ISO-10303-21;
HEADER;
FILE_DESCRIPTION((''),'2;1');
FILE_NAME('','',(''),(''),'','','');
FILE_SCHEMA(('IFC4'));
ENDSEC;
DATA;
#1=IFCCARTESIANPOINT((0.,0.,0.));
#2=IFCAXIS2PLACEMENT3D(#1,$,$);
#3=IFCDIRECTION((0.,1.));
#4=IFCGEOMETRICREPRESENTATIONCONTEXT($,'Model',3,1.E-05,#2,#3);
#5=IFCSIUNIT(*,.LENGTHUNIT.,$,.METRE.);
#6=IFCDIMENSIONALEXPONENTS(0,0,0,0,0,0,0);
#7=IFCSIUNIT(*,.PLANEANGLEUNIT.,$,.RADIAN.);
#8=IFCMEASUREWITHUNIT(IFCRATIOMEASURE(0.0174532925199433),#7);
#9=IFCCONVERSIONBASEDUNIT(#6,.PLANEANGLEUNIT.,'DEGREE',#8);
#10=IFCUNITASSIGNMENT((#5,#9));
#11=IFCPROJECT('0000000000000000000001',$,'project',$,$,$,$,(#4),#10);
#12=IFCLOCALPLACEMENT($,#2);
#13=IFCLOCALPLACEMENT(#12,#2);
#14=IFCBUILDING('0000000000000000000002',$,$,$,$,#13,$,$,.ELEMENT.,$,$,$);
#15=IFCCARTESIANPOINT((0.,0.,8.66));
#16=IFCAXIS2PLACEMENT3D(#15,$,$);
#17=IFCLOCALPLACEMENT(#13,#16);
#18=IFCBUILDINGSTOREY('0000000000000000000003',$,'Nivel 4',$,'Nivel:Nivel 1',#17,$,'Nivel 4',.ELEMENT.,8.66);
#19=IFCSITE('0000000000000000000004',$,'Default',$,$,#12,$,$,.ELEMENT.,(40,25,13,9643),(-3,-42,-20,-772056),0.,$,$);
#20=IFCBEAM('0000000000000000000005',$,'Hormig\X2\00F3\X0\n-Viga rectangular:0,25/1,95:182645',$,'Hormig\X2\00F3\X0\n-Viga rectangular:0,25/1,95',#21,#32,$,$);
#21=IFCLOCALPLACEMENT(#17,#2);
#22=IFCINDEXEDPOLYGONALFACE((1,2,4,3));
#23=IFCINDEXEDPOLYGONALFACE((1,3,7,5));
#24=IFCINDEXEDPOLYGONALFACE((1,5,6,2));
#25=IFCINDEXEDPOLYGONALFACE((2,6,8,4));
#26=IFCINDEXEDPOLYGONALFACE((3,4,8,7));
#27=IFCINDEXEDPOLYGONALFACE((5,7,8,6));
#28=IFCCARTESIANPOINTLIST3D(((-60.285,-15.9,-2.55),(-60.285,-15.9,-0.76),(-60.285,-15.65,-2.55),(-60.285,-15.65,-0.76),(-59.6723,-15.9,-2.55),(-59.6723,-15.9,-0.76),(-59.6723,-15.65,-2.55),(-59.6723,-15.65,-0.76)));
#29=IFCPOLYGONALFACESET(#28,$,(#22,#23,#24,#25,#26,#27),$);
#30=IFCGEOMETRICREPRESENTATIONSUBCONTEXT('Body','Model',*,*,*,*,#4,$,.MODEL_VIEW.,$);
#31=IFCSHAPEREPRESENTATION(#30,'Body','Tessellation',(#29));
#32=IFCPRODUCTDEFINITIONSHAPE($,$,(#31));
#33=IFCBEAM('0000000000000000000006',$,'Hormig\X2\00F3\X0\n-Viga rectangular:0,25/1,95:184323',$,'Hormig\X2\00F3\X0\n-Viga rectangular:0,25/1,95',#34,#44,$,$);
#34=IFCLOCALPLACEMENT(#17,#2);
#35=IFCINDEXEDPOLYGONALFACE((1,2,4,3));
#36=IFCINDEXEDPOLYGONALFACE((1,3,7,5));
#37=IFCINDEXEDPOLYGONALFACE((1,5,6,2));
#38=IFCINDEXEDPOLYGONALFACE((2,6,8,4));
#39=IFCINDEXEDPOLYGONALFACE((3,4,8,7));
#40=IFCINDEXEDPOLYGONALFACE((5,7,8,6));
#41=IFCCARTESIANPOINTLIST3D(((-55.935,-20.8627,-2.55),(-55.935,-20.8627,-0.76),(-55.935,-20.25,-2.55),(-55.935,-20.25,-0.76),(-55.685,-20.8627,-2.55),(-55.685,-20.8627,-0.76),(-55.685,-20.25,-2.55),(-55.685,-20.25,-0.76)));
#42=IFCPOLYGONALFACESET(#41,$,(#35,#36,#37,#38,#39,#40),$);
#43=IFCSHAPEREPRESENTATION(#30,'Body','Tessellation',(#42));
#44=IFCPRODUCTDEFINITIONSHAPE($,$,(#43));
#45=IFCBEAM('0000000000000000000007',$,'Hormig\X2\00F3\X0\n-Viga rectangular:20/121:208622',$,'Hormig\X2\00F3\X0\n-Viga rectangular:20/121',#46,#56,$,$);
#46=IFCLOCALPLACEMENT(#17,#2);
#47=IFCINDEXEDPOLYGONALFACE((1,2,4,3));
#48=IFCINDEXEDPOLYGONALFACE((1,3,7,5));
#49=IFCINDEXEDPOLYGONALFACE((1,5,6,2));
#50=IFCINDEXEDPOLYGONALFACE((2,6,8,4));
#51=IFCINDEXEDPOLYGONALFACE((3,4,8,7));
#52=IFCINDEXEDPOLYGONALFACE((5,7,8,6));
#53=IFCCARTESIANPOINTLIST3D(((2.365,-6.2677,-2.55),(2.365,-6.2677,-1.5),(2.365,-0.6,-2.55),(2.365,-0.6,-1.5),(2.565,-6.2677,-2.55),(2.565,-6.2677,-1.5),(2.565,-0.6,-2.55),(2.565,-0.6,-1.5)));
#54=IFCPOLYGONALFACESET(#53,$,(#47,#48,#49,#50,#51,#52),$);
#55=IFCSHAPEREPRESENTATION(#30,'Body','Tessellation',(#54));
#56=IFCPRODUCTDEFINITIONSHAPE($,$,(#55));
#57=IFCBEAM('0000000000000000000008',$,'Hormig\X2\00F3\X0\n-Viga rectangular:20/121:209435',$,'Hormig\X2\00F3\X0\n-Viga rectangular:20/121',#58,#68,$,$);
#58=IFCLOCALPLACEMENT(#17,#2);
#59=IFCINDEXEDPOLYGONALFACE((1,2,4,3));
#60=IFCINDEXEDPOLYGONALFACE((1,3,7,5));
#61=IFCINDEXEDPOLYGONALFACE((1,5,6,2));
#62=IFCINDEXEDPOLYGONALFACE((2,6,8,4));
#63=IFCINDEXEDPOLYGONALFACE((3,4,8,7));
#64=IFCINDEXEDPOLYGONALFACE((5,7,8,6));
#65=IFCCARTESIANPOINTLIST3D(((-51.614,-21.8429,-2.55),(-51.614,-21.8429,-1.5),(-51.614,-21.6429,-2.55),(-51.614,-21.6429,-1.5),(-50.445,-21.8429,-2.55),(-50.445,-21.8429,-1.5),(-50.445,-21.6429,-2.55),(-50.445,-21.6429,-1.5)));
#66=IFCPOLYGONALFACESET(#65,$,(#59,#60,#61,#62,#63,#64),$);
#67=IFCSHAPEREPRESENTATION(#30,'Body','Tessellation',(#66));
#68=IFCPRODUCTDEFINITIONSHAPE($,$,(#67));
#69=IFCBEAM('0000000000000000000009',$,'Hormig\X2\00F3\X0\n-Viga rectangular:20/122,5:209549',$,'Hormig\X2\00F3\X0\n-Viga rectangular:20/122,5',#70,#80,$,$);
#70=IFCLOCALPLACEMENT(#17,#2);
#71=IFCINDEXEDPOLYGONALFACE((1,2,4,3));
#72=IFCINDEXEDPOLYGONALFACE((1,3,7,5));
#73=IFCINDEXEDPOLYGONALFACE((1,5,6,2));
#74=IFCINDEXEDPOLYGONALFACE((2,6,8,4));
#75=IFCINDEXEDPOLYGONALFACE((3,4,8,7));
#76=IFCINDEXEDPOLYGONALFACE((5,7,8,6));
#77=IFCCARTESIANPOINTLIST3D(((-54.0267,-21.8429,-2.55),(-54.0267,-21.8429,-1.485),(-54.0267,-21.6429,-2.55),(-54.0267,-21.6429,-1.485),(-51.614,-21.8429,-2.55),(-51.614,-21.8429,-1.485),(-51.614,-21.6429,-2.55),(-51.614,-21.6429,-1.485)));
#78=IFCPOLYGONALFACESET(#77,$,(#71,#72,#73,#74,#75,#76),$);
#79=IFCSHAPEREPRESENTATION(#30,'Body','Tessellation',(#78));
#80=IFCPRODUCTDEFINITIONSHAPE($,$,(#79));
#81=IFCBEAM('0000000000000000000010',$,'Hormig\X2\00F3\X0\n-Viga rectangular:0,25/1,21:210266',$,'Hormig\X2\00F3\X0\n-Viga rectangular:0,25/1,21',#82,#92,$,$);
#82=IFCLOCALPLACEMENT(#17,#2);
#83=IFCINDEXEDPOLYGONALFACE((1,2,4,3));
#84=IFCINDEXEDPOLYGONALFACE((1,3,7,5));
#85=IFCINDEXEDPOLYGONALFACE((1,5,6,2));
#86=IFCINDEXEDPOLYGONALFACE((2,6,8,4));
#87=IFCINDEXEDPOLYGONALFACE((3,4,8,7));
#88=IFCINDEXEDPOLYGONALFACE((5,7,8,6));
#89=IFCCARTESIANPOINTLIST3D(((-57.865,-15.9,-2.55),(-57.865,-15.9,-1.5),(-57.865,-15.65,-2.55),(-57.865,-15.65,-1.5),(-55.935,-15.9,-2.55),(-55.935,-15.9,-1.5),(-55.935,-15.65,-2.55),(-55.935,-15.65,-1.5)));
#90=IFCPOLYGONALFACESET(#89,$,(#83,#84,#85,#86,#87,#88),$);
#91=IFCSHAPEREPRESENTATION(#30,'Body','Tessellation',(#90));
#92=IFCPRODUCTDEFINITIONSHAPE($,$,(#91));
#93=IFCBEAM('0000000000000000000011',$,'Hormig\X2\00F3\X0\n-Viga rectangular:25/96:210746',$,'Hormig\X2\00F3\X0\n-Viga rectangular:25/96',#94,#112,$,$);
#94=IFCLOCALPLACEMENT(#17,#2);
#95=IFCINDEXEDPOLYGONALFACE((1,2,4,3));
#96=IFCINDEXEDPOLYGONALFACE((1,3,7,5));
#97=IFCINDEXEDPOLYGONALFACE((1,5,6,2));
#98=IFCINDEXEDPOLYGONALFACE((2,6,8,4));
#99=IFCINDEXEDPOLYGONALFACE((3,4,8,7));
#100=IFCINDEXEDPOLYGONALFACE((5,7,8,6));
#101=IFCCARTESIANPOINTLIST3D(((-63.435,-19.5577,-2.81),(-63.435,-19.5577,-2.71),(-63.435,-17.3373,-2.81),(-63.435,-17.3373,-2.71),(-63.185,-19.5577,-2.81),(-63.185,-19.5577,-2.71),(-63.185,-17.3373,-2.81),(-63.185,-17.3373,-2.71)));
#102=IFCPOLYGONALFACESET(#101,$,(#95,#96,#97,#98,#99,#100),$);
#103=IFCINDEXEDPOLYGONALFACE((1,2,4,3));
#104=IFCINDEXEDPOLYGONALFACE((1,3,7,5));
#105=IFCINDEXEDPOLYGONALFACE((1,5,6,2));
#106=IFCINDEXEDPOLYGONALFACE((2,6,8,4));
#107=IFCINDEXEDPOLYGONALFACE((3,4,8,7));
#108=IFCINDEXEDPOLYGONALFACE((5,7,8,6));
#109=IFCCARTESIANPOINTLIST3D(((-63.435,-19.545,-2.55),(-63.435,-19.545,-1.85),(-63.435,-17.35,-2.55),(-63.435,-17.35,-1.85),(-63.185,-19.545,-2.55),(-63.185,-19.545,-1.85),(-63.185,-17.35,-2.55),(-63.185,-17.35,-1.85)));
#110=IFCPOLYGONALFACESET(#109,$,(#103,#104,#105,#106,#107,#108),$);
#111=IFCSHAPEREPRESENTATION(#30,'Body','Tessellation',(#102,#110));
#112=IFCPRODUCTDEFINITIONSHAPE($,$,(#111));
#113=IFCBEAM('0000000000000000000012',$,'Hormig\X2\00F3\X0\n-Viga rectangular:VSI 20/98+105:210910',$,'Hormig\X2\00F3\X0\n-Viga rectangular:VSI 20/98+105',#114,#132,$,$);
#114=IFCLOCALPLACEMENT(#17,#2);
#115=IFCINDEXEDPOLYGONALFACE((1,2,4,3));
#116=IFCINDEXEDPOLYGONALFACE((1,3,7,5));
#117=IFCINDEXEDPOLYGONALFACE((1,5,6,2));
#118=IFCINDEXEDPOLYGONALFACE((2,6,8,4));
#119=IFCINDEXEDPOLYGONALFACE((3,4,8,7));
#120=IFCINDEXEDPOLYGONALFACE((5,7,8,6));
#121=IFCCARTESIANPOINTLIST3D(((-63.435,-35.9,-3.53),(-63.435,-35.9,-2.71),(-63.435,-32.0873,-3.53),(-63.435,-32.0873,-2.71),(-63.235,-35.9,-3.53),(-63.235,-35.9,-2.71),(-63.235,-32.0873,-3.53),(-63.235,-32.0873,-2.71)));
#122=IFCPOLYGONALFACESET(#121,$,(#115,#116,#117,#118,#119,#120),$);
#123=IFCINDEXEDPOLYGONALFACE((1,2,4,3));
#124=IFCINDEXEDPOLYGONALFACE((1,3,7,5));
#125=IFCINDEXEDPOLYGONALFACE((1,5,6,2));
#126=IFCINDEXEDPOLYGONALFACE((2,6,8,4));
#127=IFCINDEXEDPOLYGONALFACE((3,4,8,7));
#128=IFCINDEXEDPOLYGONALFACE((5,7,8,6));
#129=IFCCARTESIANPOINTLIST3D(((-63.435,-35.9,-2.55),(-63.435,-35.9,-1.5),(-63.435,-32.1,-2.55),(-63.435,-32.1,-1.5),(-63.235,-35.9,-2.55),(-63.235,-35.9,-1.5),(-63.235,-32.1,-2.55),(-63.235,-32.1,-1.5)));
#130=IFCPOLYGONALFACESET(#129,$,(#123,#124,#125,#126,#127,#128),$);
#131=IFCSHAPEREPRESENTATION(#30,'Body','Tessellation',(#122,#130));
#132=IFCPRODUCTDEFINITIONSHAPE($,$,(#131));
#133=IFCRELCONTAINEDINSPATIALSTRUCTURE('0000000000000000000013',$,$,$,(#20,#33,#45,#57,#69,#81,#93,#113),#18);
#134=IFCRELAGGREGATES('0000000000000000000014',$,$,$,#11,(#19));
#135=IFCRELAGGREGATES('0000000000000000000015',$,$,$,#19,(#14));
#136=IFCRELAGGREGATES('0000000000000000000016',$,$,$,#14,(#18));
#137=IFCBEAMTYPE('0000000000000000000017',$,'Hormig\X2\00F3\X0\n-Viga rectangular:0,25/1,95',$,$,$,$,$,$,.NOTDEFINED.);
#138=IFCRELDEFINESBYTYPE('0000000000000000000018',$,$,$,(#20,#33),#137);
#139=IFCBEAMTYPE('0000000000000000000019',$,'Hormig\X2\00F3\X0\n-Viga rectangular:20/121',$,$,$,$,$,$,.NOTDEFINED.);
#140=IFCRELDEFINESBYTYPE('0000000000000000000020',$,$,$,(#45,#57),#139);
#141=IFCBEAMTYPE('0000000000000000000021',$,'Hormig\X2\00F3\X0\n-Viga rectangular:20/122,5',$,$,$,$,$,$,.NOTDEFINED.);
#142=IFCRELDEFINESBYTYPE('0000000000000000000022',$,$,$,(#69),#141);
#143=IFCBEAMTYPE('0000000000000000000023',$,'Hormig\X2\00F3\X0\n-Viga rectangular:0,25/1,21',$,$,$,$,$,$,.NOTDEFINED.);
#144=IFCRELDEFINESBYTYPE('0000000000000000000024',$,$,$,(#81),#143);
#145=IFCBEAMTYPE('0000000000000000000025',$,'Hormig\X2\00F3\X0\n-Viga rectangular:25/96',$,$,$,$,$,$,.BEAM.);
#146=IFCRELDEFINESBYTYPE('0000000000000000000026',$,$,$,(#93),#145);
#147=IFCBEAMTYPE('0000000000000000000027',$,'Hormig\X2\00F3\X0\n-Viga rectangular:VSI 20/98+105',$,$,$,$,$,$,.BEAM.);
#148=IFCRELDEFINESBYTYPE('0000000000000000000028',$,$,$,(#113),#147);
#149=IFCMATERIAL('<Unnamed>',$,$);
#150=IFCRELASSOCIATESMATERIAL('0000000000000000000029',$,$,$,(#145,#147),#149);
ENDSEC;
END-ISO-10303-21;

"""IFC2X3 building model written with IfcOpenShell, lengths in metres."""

from ifc_helpers import new_model, entity, si_unit, converted_unit, direction, frame, frame_2d, origin, place, context, subcontext, project, spatial, rectangle, extrude, source, transform, mapped, material, type_object, type_shapes, element, save


model = new_model("IFC2X3")

# Units and contexts
model_context = context("Model", 3, precision=1e-05, world=origin(), true_north=direction((0.0, 1.0)))
body_context = subcontext(model_context, "Body", "Model", "MODEL_VIEW")
ifc_project = project(units=[si_unit("LENGTHUNIT", "METRE"), converted_unit("PLANEANGLEUNIT", "DEGREE", entity("IfcRatioMeasure", 0.0174532925199433), si_unit("PLANEANGLEUNIT", "RADIAN"), dimensions=[0, 0, 0, 0, 0, 0, 0])], contexts=[model_context])

# Site, building, storey
site_placement = place(None, origin())
site = spatial("IfcSite", under=ifc_project, at=site_placement, Name="Default", CompositionType="ELEMENT", RefLatitude=(40, 25, 13, 9643), RefLongitude=(-3, -42, -20, -772056), RefElevation=0.0)
building_placement = place(site_placement, origin())
building = spatial("IfcBuilding", under=site, at=building_placement, CompositionType="ELEMENT")
storey_placement = place(building_placement, frame((0.0, 0.0, 8.66)))
storey = spatial("IfcBuildingStorey", under=building, at=storey_placement, Name="Nivel 4", ObjectType="Nivel:Nivel 1", LongName="Nivel 4", CompositionType="ELEMENT", Elevation=8.66)

# Beams
beam_type_1 = type_object("IfcBeamType", Name="Hormigón-Viga rectangular:0,25/1,95", PredefinedType="NOTDEFINED")
beam_1_placement = place(storey_placement, frame((-60.285, -15.775, -0.76)))
element("IfcBeam", 1, at=beam_1_placement, inside=storey, type_object=beam_type_1, Name="Hormigón-Viga rectangular:0,25/1,95:182645", ObjectType="Hormigón-Viga rectangular:0,25/1,95", context=body_context, shape_type="SweptSolid", body=[
    extrude(rectangle(XDim=1.79, YDim=0.25, at=frame_2d((0.0, 0.0), x_axis=(1.0, 0.0))), frame((0.0, 0.0, -0.895), z_axis=(1.0, 0.0, 0.0), x_axis=(0.0, 0.0, -1.0)), (0.0, 0.0, 1.0), 0.6127),
])
beam_2_placement = place(storey_placement, frame((-55.81, -20.25, -0.76), z_axis=(0.0, 0.0, 1.0), x_axis=(0.0, -1.0, 0.0)))
element("IfcBeam", 2, at=beam_2_placement, inside=storey, type_object=beam_type_1, Name="Hormigón-Viga rectangular:0,25/1,95:184323", ObjectType="Hormigón-Viga rectangular:0,25/1,95", context=body_context, shape_type="SweptSolid", body=[
    extrude(rectangle(XDim=1.79, YDim=0.25, at=frame_2d((0.0, 0.0), x_axis=(1.0, 0.0))), frame((0.0, 0.0, -0.895), z_axis=(1.0, 0.0, 0.0), x_axis=(0.0, 0.0, -1.0)), (0.0, 0.0, 1.0), 0.6127),
])
beam_type_2 = type_object("IfcBeamType", Name="Hormigón-Viga rectangular:20/121", PredefinedType="NOTDEFINED")
beam_3_placement = place(storey_placement, frame((2.465, -0.475, -1.5), z_axis=(0.0, 0.0, 1.0), x_axis=(0.0, -1.0, 0.0)))
element("IfcBeam", 3, at=beam_3_placement, inside=storey, type_object=beam_type_2, Name="Hormigón-Viga rectangular:20/121:208622", ObjectType="Hormigón-Viga rectangular:20/121", context=body_context, shape_type="SweptSolid", body=[
    extrude(rectangle(XDim=1.05, YDim=0.2, at=frame_2d((0.0, 0.0), x_axis=(1.0, 0.0))), frame((0.125, 0.0, -0.525), z_axis=(1.0, 0.0, 0.0), x_axis=(0.0, 0.0, -1.0)), (0.0, 0.0, 1.0), 5.6677),
])
beam_4_placement = place(storey_placement, frame((-51.6267, -21.7429, -1.5)))
element("IfcBeam", 4, at=beam_4_placement, inside=storey, type_object=beam_type_2, Name="Hormigón-Viga rectangular:20/121:209435", ObjectType="Hormigón-Viga rectangular:20/121", context=body_context, shape_type="SweptSolid", body=[
    extrude(rectangle(XDim=1.05, YDim=0.2, at=frame_2d((0.0, 0.0), x_axis=(1.0, 0.0))), frame((0.0127, 0.0, -0.525), z_axis=(1.0, 0.0, 0.0), x_axis=(0.0, 0.0, -1.0)), (0.0, 0.0, 1.0), 1.169),
])
beam_type_3 = type_object("IfcBeamType", Name="Hormigón-Viga rectangular:20/122,5", PredefinedType="NOTDEFINED")
beam_5_placement = place(storey_placement, frame((-54.0267, -21.7429, -1.485)))
element("IfcBeam", 5, at=beam_5_placement, inside=storey, type_object=beam_type_3, Name="Hormigón-Viga rectangular:20/122,5:209549", ObjectType="Hormigón-Viga rectangular:20/122,5", context=body_context, shape_type="SweptSolid", body=[
    extrude(rectangle(XDim=1.065, YDim=0.2, at=frame_2d((0.0, 0.0), x_axis=(1.0, 0.0))), frame((0.0, 0.0, -0.5325), z_axis=(1.0, 0.0, 0.0), x_axis=(0.0, 0.0, -1.0)), (0.0, 0.0, 1.0), 2.4127),
])
beam_type_4 = type_object("IfcBeamType", Name="Hormigón-Viga rectangular:0,25/1,21", PredefinedType="NOTDEFINED")
beam_6_placement = place(storey_placement, frame((-57.865, -15.775, -1.5)))
element("IfcBeam", 6, at=beam_6_placement, inside=storey, type_object=beam_type_4, Name="Hormigón-Viga rectangular:0,25/1,21:210266", ObjectType="Hormigón-Viga rectangular:0,25/1,21", context=body_context, shape_type="SweptSolid", body=[
    extrude(rectangle(XDim=1.05, YDim=0.25, at=frame_2d((0.0, 0.0), x_axis=(1.0, 0.0))), frame((0.0, 0.0, -0.525), z_axis=(1.0, 0.0, 0.0), x_axis=(0.0, 0.0, -1.0)), (0.0, 0.0, 1.0), 1.93),
])
ifc_material = material(Name="<Unnamed>")
beam_type_5 = type_object("IfcBeamType", Name="Hormigón-Viga rectangular:25/96", PredefinedType="BEAM", material=ifc_material)
shared_shape_1 = source(origin(), body_context, "Body", "SweptSolid", [
    extrude(rectangle(XDim=0.1, YDim=0.25, at=frame_2d((0.0, 0.0), x_axis=(0.0, 1.0))), frame((-63.31, -19.5577, 5.9), z_axis=(0.0, 1.0, 0.0), x_axis=(-1.0, 0.0, 0.0)), (0.0, 0.0, 1.0), 2.2204),
    extrude(rectangle(XDim=0.7, YDim=0.25, at=frame_2d((0.0, 0.0), x_axis=(0.0, 1.0))), frame((-63.31, -19.545, 6.46), z_axis=(0.0, 1.0, 0.0), x_axis=(-1.0, 0.0, 0.0)), (0.0, 0.0, 1.0), 2.195),
])
type_shapes(beam_type_5, [shared_shape_1])
beam_7_placement = place(storey_placement, frame((0.0, 0.0, -8.66)))
element("IfcBeam", 7, at=beam_7_placement, inside=storey, type_object=beam_type_5, Name="Hormigón-Viga rectangular:25/96:210746", ObjectType="Hormigón-Viga rectangular:25/96", context=body_context, shape_type="MappedRepresentation", body=[
    mapped(shared_shape_1, transform((0.0, 0.0, 0.0), scale=1.0)),
])
beam_type_6 = type_object("IfcBeamType", Name="Hormigón-Viga rectangular:VSI 20/98+105", PredefinedType="BEAM", material=ifc_material)
shared_shape_2 = source(origin(), body_context, "Body", "SweptSolid", [
    extrude(rectangle(XDim=0.82, YDim=0.2, at=frame_2d((0.0, 0.0), x_axis=(0.0, 1.0))), frame((-63.335, -32.0873, 5.54), z_axis=(0.0, -1.0, 0.0), x_axis=(-1.0, 0.0, 0.0)), (0.0, 0.0, 1.0), 3.8127),
    extrude(rectangle(XDim=1.05, YDim=0.2, at=frame_2d((0.0, 0.0), x_axis=(0.0, 1.0))), frame((-63.335, -32.1, 6.635), z_axis=(0.0, -1.0, 0.0), x_axis=(-1.0, 0.0, 0.0)), (0.0, 0.0, 1.0), 3.8),
])
type_shapes(beam_type_6, [shared_shape_2])
beam_8_placement = place(storey_placement, frame((0.0, 0.0, -8.66)))
element("IfcBeam", 8, at=beam_8_placement, inside=storey, type_object=beam_type_6, Name="Hormigón-Viga rectangular:VSI 20/98+105:210910", ObjectType="Hormigón-Viga rectangular:VSI 20/98+105", context=body_context, shape_type="MappedRepresentation", body=[
    mapped(shared_shape_2, transform((0.0, 0.0, 0.0), scale=1.0)),
])

save(model, "model.ifc")
